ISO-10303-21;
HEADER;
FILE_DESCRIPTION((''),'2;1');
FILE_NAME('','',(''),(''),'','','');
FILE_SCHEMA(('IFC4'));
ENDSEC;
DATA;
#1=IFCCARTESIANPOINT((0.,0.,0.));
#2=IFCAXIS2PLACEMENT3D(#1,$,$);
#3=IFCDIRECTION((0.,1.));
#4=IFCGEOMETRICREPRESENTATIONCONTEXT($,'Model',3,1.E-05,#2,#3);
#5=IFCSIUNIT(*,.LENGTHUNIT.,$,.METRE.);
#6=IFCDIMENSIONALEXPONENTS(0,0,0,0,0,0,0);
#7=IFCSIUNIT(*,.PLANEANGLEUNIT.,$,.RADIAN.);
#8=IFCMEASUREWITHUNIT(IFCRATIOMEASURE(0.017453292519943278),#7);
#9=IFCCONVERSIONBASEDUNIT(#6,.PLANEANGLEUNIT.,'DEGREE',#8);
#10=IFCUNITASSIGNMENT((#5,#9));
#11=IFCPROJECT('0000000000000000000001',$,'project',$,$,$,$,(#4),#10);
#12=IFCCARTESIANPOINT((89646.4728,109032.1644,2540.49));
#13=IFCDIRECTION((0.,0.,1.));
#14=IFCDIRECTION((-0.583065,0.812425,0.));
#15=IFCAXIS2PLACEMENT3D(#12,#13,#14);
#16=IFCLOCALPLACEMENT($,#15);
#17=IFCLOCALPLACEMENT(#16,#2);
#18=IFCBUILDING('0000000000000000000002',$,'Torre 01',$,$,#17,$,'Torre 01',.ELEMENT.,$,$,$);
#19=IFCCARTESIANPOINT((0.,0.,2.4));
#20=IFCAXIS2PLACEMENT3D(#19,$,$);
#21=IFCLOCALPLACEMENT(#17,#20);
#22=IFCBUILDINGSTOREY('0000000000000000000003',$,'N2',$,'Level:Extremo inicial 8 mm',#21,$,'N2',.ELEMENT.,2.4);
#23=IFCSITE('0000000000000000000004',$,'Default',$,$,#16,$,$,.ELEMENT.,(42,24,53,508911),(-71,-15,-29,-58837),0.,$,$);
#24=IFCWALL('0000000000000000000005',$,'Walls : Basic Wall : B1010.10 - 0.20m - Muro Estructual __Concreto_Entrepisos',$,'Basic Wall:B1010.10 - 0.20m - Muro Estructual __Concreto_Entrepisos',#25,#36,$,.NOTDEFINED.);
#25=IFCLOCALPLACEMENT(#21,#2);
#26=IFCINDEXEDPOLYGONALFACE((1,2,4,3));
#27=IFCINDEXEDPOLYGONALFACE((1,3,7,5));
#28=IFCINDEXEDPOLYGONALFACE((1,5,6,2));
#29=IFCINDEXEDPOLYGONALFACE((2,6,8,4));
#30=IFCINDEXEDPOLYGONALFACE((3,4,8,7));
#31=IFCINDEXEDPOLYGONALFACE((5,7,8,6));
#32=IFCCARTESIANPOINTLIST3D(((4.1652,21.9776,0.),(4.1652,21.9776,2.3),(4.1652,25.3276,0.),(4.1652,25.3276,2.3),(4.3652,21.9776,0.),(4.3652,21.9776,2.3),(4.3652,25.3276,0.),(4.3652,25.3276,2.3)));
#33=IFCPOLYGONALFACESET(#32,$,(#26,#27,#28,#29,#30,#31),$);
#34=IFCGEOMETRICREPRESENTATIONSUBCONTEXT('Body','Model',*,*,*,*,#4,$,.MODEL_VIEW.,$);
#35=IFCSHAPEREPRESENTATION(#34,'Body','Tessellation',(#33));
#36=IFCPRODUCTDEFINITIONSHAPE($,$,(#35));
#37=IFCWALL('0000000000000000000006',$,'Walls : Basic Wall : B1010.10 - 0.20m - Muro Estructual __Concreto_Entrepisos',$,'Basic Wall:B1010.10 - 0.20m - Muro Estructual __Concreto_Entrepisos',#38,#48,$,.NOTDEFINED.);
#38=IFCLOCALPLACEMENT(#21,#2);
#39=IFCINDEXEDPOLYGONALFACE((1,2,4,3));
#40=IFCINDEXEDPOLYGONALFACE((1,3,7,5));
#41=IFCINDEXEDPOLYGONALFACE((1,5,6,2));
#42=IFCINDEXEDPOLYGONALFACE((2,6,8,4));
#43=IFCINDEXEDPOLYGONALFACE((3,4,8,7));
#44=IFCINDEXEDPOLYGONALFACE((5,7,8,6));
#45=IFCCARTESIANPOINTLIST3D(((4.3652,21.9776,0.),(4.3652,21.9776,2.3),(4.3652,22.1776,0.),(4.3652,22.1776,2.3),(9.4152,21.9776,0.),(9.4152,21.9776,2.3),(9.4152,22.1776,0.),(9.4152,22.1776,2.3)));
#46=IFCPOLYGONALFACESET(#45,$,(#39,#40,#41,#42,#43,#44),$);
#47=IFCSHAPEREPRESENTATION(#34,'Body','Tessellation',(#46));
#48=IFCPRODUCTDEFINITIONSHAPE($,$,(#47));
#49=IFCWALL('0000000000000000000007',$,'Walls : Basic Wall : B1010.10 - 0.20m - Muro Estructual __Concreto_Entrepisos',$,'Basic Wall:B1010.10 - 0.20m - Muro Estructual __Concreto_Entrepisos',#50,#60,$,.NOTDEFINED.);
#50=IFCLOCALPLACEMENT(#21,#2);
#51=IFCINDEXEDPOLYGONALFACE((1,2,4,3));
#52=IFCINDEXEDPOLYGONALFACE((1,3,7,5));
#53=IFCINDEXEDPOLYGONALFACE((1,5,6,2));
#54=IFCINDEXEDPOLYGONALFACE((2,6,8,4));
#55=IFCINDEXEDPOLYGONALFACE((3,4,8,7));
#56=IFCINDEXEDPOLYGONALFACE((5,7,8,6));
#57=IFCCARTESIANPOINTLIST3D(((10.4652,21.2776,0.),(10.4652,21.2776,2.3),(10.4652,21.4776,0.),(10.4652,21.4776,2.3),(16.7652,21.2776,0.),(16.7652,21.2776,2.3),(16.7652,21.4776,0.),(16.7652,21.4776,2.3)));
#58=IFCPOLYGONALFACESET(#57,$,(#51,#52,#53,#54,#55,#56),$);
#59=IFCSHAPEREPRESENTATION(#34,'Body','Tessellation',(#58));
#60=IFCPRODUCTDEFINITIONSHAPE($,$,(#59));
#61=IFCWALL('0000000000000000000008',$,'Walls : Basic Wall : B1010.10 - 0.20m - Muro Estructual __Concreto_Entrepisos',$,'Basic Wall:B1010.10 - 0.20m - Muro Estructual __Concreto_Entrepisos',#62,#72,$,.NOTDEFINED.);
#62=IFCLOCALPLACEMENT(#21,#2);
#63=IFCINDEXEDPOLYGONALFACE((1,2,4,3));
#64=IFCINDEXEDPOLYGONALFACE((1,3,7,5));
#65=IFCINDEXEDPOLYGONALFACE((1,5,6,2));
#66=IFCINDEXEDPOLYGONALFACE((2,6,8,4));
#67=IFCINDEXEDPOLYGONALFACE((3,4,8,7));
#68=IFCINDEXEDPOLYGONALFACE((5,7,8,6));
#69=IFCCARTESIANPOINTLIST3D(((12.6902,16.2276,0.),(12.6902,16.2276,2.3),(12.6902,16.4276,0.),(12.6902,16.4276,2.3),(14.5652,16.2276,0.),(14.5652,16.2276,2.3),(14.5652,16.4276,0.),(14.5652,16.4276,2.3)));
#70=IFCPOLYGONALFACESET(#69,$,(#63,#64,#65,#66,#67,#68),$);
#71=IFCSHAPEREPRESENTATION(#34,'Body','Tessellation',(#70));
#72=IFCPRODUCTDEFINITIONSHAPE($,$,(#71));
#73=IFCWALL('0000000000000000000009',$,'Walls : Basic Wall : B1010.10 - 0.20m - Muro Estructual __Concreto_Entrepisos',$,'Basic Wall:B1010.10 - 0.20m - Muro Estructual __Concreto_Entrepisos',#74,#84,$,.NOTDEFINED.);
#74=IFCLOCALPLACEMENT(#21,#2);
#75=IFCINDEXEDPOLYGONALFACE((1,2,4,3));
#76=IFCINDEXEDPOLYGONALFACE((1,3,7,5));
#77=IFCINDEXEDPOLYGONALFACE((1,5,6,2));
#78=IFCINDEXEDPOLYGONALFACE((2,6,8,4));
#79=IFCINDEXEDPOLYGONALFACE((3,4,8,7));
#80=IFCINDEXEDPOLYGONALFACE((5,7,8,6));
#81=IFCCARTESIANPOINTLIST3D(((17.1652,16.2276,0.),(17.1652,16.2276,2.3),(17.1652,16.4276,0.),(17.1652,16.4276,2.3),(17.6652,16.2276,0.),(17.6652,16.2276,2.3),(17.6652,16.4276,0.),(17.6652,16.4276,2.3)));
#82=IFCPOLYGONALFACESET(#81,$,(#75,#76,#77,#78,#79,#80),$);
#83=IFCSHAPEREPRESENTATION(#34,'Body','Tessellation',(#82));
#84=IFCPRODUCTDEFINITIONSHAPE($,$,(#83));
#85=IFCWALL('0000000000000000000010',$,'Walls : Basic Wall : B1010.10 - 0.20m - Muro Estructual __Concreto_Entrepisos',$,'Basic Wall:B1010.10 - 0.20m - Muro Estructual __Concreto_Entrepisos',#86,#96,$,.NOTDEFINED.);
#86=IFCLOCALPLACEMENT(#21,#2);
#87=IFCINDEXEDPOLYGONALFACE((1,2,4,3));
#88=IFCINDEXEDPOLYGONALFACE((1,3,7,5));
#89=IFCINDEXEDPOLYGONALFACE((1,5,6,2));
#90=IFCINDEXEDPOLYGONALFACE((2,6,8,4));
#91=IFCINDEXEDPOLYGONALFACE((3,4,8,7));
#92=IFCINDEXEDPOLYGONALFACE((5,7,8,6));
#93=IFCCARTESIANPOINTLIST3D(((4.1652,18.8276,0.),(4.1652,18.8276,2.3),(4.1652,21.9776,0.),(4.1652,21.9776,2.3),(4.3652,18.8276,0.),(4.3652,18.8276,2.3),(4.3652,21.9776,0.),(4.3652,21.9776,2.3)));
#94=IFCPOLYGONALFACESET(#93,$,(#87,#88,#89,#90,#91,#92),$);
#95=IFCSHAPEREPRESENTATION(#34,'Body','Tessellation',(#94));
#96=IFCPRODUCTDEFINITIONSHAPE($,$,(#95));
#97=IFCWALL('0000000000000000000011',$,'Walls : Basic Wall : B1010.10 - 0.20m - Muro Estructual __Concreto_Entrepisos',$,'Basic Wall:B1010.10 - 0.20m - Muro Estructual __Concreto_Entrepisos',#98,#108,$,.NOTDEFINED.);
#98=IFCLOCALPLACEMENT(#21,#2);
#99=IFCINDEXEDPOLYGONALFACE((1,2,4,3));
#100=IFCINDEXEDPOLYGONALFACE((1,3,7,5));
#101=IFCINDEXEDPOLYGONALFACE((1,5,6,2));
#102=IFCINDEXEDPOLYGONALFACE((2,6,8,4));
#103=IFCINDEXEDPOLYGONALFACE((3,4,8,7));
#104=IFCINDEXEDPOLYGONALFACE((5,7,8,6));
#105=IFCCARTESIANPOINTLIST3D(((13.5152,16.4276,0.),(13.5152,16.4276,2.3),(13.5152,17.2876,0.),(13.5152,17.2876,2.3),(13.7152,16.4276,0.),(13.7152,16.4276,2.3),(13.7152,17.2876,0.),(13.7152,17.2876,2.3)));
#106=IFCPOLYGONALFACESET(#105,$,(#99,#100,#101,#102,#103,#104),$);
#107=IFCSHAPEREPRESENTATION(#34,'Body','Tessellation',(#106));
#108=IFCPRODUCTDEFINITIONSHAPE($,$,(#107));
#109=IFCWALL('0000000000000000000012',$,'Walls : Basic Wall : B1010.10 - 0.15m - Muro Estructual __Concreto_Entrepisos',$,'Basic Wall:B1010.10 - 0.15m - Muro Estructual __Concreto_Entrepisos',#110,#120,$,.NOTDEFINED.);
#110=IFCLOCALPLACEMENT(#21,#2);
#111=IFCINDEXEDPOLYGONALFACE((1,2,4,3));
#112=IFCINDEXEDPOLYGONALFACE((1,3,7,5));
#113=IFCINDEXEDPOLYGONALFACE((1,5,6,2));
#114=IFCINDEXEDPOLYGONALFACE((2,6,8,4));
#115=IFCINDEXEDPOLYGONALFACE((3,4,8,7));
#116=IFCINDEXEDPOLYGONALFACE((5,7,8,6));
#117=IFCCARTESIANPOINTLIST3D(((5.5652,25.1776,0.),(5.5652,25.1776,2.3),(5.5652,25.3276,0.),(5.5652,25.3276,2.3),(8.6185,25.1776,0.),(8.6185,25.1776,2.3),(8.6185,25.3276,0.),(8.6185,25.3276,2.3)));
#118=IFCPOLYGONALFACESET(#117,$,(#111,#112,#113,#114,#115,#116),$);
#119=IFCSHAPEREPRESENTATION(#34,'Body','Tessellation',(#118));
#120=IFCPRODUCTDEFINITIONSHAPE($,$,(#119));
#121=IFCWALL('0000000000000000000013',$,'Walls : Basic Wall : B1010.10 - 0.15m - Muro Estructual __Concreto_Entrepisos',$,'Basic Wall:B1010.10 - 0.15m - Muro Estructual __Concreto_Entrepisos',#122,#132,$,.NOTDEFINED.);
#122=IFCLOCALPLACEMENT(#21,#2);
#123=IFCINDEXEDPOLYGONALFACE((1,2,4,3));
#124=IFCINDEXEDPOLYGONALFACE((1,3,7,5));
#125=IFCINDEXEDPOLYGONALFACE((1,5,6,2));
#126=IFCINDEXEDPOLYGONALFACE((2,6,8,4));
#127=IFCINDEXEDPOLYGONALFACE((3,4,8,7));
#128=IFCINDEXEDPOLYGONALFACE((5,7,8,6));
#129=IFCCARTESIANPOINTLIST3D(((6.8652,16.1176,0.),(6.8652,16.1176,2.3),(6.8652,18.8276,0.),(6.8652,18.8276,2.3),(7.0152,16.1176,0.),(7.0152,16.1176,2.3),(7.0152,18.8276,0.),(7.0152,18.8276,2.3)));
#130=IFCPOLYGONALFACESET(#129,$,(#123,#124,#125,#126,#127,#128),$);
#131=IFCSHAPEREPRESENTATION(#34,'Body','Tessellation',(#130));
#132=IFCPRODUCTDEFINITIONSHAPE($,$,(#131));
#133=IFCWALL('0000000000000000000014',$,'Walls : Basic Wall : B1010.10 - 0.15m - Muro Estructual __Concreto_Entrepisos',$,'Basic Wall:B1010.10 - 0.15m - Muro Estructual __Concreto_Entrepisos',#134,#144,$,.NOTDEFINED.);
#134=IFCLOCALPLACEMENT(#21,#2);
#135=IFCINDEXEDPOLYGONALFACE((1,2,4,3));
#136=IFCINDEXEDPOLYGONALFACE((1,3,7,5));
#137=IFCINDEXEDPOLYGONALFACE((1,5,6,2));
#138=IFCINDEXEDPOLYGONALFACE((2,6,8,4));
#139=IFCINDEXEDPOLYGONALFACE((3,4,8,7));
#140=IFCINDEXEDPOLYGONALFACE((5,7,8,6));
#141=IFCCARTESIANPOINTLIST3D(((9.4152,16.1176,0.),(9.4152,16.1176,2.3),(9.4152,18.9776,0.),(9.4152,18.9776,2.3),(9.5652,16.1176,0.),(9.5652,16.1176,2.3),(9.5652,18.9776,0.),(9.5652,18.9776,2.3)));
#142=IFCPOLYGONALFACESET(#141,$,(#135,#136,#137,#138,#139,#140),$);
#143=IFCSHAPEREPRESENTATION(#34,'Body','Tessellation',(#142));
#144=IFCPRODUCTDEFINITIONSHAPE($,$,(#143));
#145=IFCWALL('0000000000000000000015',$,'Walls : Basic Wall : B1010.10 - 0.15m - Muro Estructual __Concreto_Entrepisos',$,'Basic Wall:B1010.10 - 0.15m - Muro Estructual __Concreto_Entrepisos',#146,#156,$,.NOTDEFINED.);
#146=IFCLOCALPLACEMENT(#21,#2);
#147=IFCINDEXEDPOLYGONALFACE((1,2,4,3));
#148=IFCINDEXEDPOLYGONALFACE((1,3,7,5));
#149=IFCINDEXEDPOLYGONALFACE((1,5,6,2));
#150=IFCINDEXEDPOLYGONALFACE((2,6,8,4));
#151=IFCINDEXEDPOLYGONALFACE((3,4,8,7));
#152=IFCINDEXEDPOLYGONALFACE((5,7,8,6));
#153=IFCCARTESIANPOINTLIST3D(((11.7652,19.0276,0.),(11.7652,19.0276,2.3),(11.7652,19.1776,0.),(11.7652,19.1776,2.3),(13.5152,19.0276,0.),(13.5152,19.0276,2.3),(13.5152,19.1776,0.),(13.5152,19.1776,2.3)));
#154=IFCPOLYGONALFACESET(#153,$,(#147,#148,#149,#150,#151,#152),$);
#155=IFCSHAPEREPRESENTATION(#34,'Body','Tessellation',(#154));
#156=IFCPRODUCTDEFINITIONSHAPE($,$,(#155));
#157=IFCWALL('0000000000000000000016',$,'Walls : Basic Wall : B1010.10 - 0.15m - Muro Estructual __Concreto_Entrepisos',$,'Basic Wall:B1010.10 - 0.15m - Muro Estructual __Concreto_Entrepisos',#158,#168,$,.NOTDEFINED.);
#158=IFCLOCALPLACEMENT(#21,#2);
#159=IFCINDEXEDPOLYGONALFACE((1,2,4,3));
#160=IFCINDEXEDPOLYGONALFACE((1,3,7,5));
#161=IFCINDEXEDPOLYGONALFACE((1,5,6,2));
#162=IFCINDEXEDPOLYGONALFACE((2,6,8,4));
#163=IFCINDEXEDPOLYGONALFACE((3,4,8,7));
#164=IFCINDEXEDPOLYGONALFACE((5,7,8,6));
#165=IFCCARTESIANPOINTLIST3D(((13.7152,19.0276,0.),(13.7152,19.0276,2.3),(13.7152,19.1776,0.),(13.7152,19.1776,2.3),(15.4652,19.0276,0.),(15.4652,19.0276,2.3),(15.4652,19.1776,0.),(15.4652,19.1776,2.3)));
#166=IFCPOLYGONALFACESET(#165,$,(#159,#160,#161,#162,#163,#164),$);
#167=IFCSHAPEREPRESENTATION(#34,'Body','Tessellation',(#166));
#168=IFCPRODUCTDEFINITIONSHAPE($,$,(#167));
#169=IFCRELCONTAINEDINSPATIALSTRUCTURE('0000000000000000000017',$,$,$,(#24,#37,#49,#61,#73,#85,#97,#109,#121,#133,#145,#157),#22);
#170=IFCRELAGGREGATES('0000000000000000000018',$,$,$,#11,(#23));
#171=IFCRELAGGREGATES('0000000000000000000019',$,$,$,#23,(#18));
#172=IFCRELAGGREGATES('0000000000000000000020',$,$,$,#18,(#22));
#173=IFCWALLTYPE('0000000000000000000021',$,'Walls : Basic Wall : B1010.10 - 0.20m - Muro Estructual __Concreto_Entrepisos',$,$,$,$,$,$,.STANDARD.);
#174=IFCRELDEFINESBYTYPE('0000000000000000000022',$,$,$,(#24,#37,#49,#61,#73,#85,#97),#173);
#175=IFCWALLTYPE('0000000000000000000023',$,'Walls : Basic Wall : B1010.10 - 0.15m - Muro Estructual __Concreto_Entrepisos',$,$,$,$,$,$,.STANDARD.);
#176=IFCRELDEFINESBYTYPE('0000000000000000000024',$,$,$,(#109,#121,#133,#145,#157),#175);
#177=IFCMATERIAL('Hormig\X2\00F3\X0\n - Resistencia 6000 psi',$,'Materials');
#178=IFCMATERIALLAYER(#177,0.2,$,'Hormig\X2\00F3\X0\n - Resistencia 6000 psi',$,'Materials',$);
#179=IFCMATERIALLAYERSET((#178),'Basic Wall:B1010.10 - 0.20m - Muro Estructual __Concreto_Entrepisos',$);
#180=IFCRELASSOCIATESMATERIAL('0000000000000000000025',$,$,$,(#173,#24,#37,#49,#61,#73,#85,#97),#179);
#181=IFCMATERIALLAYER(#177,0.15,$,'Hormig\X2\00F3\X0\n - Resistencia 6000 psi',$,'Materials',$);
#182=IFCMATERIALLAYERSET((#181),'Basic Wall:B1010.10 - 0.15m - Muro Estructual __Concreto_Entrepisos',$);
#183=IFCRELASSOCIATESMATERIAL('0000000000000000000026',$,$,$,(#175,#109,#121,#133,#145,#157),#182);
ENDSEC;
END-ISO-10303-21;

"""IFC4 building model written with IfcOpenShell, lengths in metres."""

from ifc_helpers import new_model, entity, si_unit, converted_unit, direction, frame, frame_2d, origin, place, context, subcontext, project, spatial, rectangle, extrude, material, layer, layer_set, layer_usage, type_object, element, save


model = new_model("IFC4")

# Units and contexts
model_context = context("Model", 3, precision=1e-05, world=origin(), true_north=direction((0.0, 1.0)))
body_context = subcontext(model_context, "Body", "Model", "MODEL_VIEW")
ifc_project = project(units=[si_unit("LENGTHUNIT", "METRE"), converted_unit("PLANEANGLEUNIT", "DEGREE", entity("IfcRatioMeasure", 0.017453292519943278), si_unit("PLANEANGLEUNIT", "RADIAN"), dimensions=[0, 0, 0, 0, 0, 0, 0])], contexts=[model_context])

# Site, building, storey
site_placement = place(None, frame((89646.4728, 109032.1644, 2540.49), z_axis=(0.0, 0.0, 1.0), x_axis=(-0.583065, 0.812425, 0.0)))
site = spatial("IfcSite", under=ifc_project, at=site_placement, Name="Default", CompositionType="ELEMENT", RefLatitude=(42, 24, 53, 508911), RefLongitude=(-71, -15, -29, -58837), RefElevation=0.0)
building_placement = place(site_placement, origin())
building = spatial("IfcBuilding", under=site, at=building_placement, Name="Torre 01", LongName="Torre 01", CompositionType="ELEMENT")
storey_placement = place(building_placement, frame((0.0, 0.0, 2.4)))
storey = spatial("IfcBuildingStorey", under=building, at=storey_placement, Name="N2", ObjectType="Level:Extremo inicial 8 mm", LongName="N2", CompositionType="ELEMENT", Elevation=2.4)

# Walls
ifc_material = material(Name="Hormigón - Resistencia 6000 psi", Category="Materials")
ifc_layer_1 = layer(ifc_material, 0.2, Name="Hormigón - Resistencia 6000 psi", Category="Materials")
ifc_layer_set_1 = layer_set([ifc_layer_1], Name="Basic Wall:B1010.10 - 0.20m - Muro Estructual __Concreto_Entrepisos")
ifc_layer_usage_1 = layer_usage(ifc_layer_set_1, "AXIS2", "NEGATIVE", 0.1)
wall_type_1 = type_object("IfcWallType", Name="Walls : Basic Wall : B1010.10 - 0.20m - Muro Estructual __Concreto_Entrepisos", PredefinedType="STANDARD", material=ifc_layer_set_1)
wall_1_placement = place(storey_placement, frame((4.2652, 25.3276, 0.0), z_axis=(0.0, 0.0, 1.0), x_axis=(0.0, -1.0, 0.0)))
element("IfcWall", 1, at=wall_1_placement, inside=storey, type_object=wall_type_1, material=ifc_layer_usage_1, Name="Walls : Basic Wall : B1010.10 - 0.20m - Muro Estructual __Concreto_Entrepisos", ObjectType="Basic Wall:B1010.10 - 0.20m - Muro Estructual __Concreto_Entrepisos", PredefinedType="NOTDEFINED", context=body_context, shape_type="SweptSolid", body=[
    extrude(rectangle(XDim=3.35, YDim=0.2, at=frame_2d((1.675, 0.0), x_axis=(-1.0, 0.0))), origin(), (0.0, 0.0, 1.0), 2.3),
])
ifc_layer_usage_2 = layer_usage(ifc_layer_set_1, "AXIS2", "NEGATIVE", 0.1)
wall_2_placement = place(storey_placement, frame((4.3652, 22.0776, 0.0)))
element("IfcWall", 2, at=wall_2_placement, inside=storey, type_object=wall_type_1, material=ifc_layer_usage_2, Name="Walls : Basic Wall : B1010.10 - 0.20m - Muro Estructual __Concreto_Entrepisos", ObjectType="Basic Wall:B1010.10 - 0.20m - Muro Estructual __Concreto_Entrepisos", PredefinedType="NOTDEFINED", context=body_context, shape_type="SweptSolid", body=[
    extrude(rectangle(XDim=5.05, YDim=0.2, at=frame_2d((2.525, 0.0), x_axis=(-1.0, 0.0))), origin(), (0.0, 0.0, 1.0), 2.3),
])
ifc_layer_usage_3 = layer_usage(ifc_layer_set_1, "AXIS2", "NEGATIVE", 0.1)
wall_3_placement = place(storey_placement, frame((10.4652, 21.3776, 0.0)))
element("IfcWall", 3, at=wall_3_placement, inside=storey, type_object=wall_type_1, material=ifc_layer_usage_3, Name="Walls : Basic Wall : B1010.10 - 0.20m - Muro Estructual __Concreto_Entrepisos", ObjectType="Basic Wall:B1010.10 - 0.20m - Muro Estructual __Concreto_Entrepisos", PredefinedType="NOTDEFINED", context=body_context, shape_type="SweptSolid", body=[
    extrude(rectangle(XDim=6.3, YDim=0.2, at=frame_2d((3.15, 0.0), x_axis=(-1.0, 0.0))), origin(), (0.0, 0.0, 1.0), 2.3),
])
ifc_layer_usage_4 = layer_usage(ifc_layer_set_1, "AXIS2", "NEGATIVE", 0.1)
wall_4_placement = place(storey_placement, frame((12.6902, 16.3276, 0.0)))
element("IfcWall", 4, at=wall_4_placement, inside=storey, type_object=wall_type_1, material=ifc_layer_usage_4, Name="Walls : Basic Wall : B1010.10 - 0.20m - Muro Estructual __Concreto_Entrepisos", ObjectType="Basic Wall:B1010.10 - 0.20m - Muro Estructual __Concreto_Entrepisos", PredefinedType="NOTDEFINED", context=body_context, shape_type="SweptSolid", body=[
    extrude(rectangle(XDim=1.875, YDim=0.2, at=frame_2d((0.9375, 0.0), x_axis=(-1.0, 0.0))), origin(), (0.0, 0.0, 1.0), 2.3),
])
ifc_layer_usage_5 = layer_usage(ifc_layer_set_1, "AXIS2", "NEGATIVE", 0.1)
wall_5_placement = place(storey_placement, frame((17.6652, 16.3276, 0.0), z_axis=(0.0, 0.0, 1.0), x_axis=(-1.0, 0.0, 0.0)))
element("IfcWall", 5, at=wall_5_placement, inside=storey, type_object=wall_type_1, material=ifc_layer_usage_5, Name="Walls : Basic Wall : B1010.10 - 0.20m - Muro Estructual __Concreto_Entrepisos", ObjectType="Basic Wall:B1010.10 - 0.20m - Muro Estructual __Concreto_Entrepisos", PredefinedType="NOTDEFINED", context=body_context, shape_type="SweptSolid", body=[
    extrude(rectangle(XDim=0.5, YDim=0.2, at=frame_2d((0.25, 0.0), x_axis=(-1.0, 0.0))), origin(), (0.0, 0.0, 1.0), 2.3),
])
ifc_layer_usage_6 = layer_usage(ifc_layer_set_1, "AXIS2", "NEGATIVE", 0.1)
wall_6_placement = place(storey_placement, frame((4.2652, 21.9776, 0.0), z_axis=(0.0, 0.0, 1.0), x_axis=(0.0, -1.0, 0.0)))
element("IfcWall", 6, at=wall_6_placement, inside=storey, type_object=wall_type_1, material=ifc_layer_usage_6, Name="Walls : Basic Wall : B1010.10 - 0.20m - Muro Estructual __Concreto_Entrepisos", ObjectType="Basic Wall:B1010.10 - 0.20m - Muro Estructual __Concreto_Entrepisos", PredefinedType="NOTDEFINED", context=body_context, shape_type="SweptSolid", body=[
    extrude(rectangle(XDim=3.15, YDim=0.2, at=frame_2d((1.575, 0.0), x_axis=(-1.0, 0.0))), origin(), (0.0, 0.0, 1.0), 2.3),
])
ifc_layer_usage_7 = layer_usage(ifc_layer_set_1, "AXIS2", "NEGATIVE", 0.1)
wall_7_placement = place(storey_placement, frame((13.6152, 17.2876, 0.0), z_axis=(0.0, 0.0, 1.0), x_axis=(0.0, -1.0, 0.0)))
element("IfcWall", 7, at=wall_7_placement, inside=storey, type_object=wall_type_1, material=ifc_layer_usage_7, Name="Walls : Basic Wall : B1010.10 - 0.20m - Muro Estructual __Concreto_Entrepisos", ObjectType="Basic Wall:B1010.10 - 0.20m - Muro Estructual __Concreto_Entrepisos", PredefinedType="NOTDEFINED", context=body_context, shape_type="SweptSolid", body=[
    extrude(rectangle(XDim=0.86, YDim=0.2, at=frame_2d((0.43, 0.0), x_axis=(-1.0, 0.0))), origin(), (0.0, 0.0, 1.0), 2.3),
])
ifc_layer_2 = layer(ifc_material, 0.15, Name="Hormigón - Resistencia 6000 psi", Category="Materials")
ifc_layer_set_2 = layer_set([ifc_layer_2], Name="Basic Wall:B1010.10 - 0.15m - Muro Estructual __Concreto_Entrepisos")
ifc_layer_usage_8 = layer_usage(ifc_layer_set_2, "AXIS2", "NEGATIVE", 0.075)
wall_type_2 = type_object("IfcWallType", Name="Walls : Basic Wall : B1010.10 - 0.15m - Muro Estructual __Concreto_Entrepisos", PredefinedType="STANDARD", material=ifc_layer_set_2)
wall_8_placement = place(storey_placement, frame((5.5652, 25.2526, 0.0)))
element("IfcWall", 8, at=wall_8_placement, inside=storey, type_object=wall_type_2, material=ifc_layer_usage_8, Name="Walls : Basic Wall : B1010.10 - 0.15m - Muro Estructual __Concreto_Entrepisos", ObjectType="Basic Wall:B1010.10 - 0.15m - Muro Estructual __Concreto_Entrepisos", PredefinedType="NOTDEFINED", context=body_context, shape_type="SweptSolid", body=[
    extrude(rectangle(XDim=3.0533, YDim=0.15, at=frame_2d((1.5267, 0.0), x_axis=(-1.0, 0.0))), origin(), (0.0, 0.0, 1.0), 2.3),
])
ifc_layer_usage_9 = layer_usage(ifc_layer_set_2, "AXIS2", "NEGATIVE", 0.075)
wall_9_placement = place(storey_placement, frame((6.9402, 18.8276, 0.0), z_axis=(0.0, 0.0, 1.0), x_axis=(0.0, -1.0, 0.0)))
element("IfcWall", 9, at=wall_9_placement, inside=storey, type_object=wall_type_2, material=ifc_layer_usage_9, Name="Walls : Basic Wall : B1010.10 - 0.15m - Muro Estructual __Concreto_Entrepisos", ObjectType="Basic Wall:B1010.10 - 0.15m - Muro Estructual __Concreto_Entrepisos", PredefinedType="NOTDEFINED", context=body_context, shape_type="SweptSolid", body=[
    extrude(rectangle(XDim=2.71, YDim=0.15, at=frame_2d((1.355, 0.0), x_axis=(-1.0, 0.0))), origin(), (0.0, 0.0, 1.0), 2.3),
])
ifc_layer_usage_10 = layer_usage(ifc_layer_set_2, "AXIS2", "NEGATIVE", 0.075)
wall_10_placement = place(storey_placement, frame((9.4902, 18.9776, 0.0), z_axis=(0.0, 0.0, 1.0), x_axis=(0.0, -1.0, 0.0)))
element("IfcWall", 10, at=wall_10_placement, inside=storey, type_object=wall_type_2, material=ifc_layer_usage_10, Name="Walls : Basic Wall : B1010.10 - 0.15m - Muro Estructual __Concreto_Entrepisos", ObjectType="Basic Wall:B1010.10 - 0.15m - Muro Estructual __Concreto_Entrepisos", PredefinedType="NOTDEFINED", context=body_context, shape_type="SweptSolid", body=[
    extrude(rectangle(XDim=2.86, YDim=0.15, at=frame_2d((1.43, 0.0), x_axis=(-1.0, 0.0))), origin(), (0.0, 0.0, 1.0), 2.3),
])
ifc_layer_usage_11 = layer_usage(ifc_layer_set_2, "AXIS2", "NEGATIVE", 0.075)
wall_11_placement = place(storey_placement, frame((11.7652, 19.1026, 0.0)))
element("IfcWall", 11, at=wall_11_placement, inside=storey, type_object=wall_type_2, material=ifc_layer_usage_11, Name="Walls : Basic Wall : B1010.10 - 0.15m - Muro Estructual __Concreto_Entrepisos", ObjectType="Basic Wall:B1010.10 - 0.15m - Muro Estructual __Concreto_Entrepisos", PredefinedType="NOTDEFINED", context=body_context, shape_type="SweptSolid", body=[
    extrude(rectangle(XDim=1.75, YDim=0.15, at=frame_2d((0.875, 0.0), x_axis=(-1.0, 0.0))), origin(), (0.0, 0.0, 1.0), 2.3),
])
ifc_layer_usage_12 = layer_usage(ifc_layer_set_2, "AXIS2", "NEGATIVE", 0.075)
wall_12_placement = place(storey_placement, frame((13.7152, 19.1026, 0.0)))
element("IfcWall", 12, at=wall_12_placement, inside=storey, type_object=wall_type_2, material=ifc_layer_usage_12, Name="Walls : Basic Wall : B1010.10 - 0.15m - Muro Estructual __Concreto_Entrepisos", ObjectType="Basic Wall:B1010.10 - 0.15m - Muro Estructual __Concreto_Entrepisos", PredefinedType="NOTDEFINED", context=body_context, shape_type="SweptSolid", body=[
    extrude(rectangle(XDim=1.75, YDim=0.15, at=frame_2d((0.875, 0.0), x_axis=(-1.0, 0.0))), origin(), (0.0, 0.0, 1.0), 2.3),
])

save(model, "model.ifc")
